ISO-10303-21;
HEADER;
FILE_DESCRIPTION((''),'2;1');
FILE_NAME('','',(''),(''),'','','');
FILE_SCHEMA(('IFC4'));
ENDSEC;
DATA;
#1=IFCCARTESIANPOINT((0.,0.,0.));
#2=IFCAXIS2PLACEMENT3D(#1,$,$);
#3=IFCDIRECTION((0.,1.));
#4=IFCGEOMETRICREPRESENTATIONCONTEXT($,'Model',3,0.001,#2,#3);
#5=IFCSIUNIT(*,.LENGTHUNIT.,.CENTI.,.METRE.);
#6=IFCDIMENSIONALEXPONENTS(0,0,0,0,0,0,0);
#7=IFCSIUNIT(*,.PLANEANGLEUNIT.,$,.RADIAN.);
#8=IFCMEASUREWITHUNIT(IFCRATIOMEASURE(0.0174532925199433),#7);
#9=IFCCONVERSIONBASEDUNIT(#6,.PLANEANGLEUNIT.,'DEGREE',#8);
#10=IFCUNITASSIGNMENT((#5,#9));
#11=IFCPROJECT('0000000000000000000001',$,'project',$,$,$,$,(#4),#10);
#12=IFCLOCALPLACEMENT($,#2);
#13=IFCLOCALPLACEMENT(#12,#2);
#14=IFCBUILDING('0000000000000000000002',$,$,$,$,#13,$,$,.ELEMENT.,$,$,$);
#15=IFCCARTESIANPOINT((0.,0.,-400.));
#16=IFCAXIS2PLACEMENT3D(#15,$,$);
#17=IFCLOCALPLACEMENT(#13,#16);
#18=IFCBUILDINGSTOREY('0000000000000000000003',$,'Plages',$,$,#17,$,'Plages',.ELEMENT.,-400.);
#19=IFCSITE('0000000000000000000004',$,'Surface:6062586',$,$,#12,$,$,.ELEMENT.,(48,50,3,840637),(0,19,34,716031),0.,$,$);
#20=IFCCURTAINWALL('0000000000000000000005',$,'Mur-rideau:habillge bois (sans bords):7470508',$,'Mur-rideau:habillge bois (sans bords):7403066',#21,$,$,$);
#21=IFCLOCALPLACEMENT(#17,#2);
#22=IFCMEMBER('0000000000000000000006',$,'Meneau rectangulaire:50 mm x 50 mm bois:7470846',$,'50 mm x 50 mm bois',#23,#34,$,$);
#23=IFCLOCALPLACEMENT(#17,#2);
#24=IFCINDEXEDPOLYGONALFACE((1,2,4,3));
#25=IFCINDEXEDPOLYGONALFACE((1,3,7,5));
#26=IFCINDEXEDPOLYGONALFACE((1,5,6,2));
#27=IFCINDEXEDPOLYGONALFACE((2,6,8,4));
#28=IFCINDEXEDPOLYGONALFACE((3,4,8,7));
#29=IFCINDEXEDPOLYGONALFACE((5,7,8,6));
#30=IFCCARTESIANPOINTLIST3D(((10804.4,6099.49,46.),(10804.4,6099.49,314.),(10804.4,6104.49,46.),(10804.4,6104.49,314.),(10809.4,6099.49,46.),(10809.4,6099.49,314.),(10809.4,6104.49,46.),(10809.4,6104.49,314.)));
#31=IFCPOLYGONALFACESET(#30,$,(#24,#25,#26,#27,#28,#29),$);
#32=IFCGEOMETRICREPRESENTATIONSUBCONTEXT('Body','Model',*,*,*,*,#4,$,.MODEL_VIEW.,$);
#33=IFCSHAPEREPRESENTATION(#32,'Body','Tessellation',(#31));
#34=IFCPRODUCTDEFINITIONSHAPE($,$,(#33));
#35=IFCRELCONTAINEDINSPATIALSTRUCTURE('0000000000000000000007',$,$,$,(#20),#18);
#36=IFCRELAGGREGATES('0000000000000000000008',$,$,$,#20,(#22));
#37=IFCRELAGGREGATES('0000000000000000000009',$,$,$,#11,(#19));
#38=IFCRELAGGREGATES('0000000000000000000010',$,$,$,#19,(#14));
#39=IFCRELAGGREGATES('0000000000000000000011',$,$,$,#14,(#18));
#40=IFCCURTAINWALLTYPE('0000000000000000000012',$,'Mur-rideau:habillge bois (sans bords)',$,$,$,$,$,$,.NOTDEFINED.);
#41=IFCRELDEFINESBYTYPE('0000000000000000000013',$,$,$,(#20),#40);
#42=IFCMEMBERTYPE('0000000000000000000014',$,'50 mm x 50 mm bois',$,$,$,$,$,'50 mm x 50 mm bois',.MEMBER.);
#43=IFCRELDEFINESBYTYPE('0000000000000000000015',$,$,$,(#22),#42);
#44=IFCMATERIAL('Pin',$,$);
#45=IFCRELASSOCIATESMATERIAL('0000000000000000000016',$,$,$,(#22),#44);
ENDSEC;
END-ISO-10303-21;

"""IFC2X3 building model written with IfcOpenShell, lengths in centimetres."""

from ifc_helpers import new_model, entity, si_unit, converted_unit, direction, frame, origin, origin_2d_with_axis, place, context, subcontext, project, spatial, rectangle, extrude, source, transform, mapped, material, type_object, type_shapes, element, aggregate, save


model = new_model("IFC2X3")

# Units and contexts
model_context = context("Model", 3, precision=0.001, world=origin(), true_north=direction((0.0, 1.0)))
body_context = subcontext(model_context, "Body", "Model", "MODEL_VIEW")
ifc_project = project(units=[si_unit("LENGTHUNIT", "METRE", prefix="CENTI"), converted_unit("PLANEANGLEUNIT", "DEGREE", entity("IfcRatioMeasure", 0.0174532925199433), si_unit("PLANEANGLEUNIT", "RADIAN"), dimensions=[0, 0, 0, 0, 0, 0, 0])], contexts=[model_context])

# Site, building, storey
site_placement = place(None, origin())
site = spatial("IfcSite", under=ifc_project, at=site_placement, Name="Surface:6062586", CompositionType="ELEMENT", RefLatitude=(48, 50, 3, 840637), RefLongitude=(0, 19, 34, 716031), RefElevation=0.0)
building_placement = place(site_placement, origin())
building = spatial("IfcBuilding", under=site, at=building_placement, CompositionType="ELEMENT")
storey_placement = place(building_placement, frame((0.0, 0.0, -400.0)))
storey = spatial("IfcBuildingStorey", under=building, at=storey_placement, Name="Plages", LongName="Plages", CompositionType="ELEMENT", Elevation=-400.0)

# Curtain wall, member
curtain_wall_type = type_object("IfcCurtainWallType", Name="Mur-rideau:habillge bois (sans bords)", PredefinedType="NOTDEFINED")
curtain_wall_placement = place(storey_placement, frame((0.0, 0.0, 400.0)))
curtain_wall = element("IfcCurtainWall", 1, at=curtain_wall_placement, inside=storey, type_object=curtain_wall_type, Name="Mur-rideau:habillge bois (sans bords):7470508", ObjectType="Mur-rideau:habillge bois (sans bords):7403066")
ifc_material = material(Name="Pin")
member_type = type_object("IfcMemberType", Name="50 mm x 50 mm bois", ElementType="50 mm x 50 mm bois", PredefinedType="MEMBER")
shared_shape = source(origin(), body_context, "Body", "SweptSolid", [
    extrude(rectangle(XDim=5.0, YDim=5.0, at=origin_2d_with_axis()), frame((0.0, 0.0, -268.0), z_axis=(0.0, 0.0, 1.0), x_axis=(0.0, -1.0, 0.0)), (0.0, 0.0, 1.0), 268.0),
])
type_shapes(member_type, [shared_shape])
member_1_placement = place(storey_placement, frame((10806.9, 6101.99, 46.0), z_axis=(0.0, 0.0, -1.0), x_axis=(0.0, 1.0, 0.0)))
member_1 = element("IfcMember", 2, at=member_1_placement, type_object=member_type, material=ifc_material, Name="Meneau rectangulaire:50 mm x 50 mm bois:7470846", ObjectType="50 mm x 50 mm bois", context=body_context, shape_type="MappedRepresentation", body=[
    mapped(shared_shape, transform((0.0, 0.0, 0.0), scale=1.0)),
])
aggregate(curtain_wall, [member_1])

save(model, "model.ifc")
